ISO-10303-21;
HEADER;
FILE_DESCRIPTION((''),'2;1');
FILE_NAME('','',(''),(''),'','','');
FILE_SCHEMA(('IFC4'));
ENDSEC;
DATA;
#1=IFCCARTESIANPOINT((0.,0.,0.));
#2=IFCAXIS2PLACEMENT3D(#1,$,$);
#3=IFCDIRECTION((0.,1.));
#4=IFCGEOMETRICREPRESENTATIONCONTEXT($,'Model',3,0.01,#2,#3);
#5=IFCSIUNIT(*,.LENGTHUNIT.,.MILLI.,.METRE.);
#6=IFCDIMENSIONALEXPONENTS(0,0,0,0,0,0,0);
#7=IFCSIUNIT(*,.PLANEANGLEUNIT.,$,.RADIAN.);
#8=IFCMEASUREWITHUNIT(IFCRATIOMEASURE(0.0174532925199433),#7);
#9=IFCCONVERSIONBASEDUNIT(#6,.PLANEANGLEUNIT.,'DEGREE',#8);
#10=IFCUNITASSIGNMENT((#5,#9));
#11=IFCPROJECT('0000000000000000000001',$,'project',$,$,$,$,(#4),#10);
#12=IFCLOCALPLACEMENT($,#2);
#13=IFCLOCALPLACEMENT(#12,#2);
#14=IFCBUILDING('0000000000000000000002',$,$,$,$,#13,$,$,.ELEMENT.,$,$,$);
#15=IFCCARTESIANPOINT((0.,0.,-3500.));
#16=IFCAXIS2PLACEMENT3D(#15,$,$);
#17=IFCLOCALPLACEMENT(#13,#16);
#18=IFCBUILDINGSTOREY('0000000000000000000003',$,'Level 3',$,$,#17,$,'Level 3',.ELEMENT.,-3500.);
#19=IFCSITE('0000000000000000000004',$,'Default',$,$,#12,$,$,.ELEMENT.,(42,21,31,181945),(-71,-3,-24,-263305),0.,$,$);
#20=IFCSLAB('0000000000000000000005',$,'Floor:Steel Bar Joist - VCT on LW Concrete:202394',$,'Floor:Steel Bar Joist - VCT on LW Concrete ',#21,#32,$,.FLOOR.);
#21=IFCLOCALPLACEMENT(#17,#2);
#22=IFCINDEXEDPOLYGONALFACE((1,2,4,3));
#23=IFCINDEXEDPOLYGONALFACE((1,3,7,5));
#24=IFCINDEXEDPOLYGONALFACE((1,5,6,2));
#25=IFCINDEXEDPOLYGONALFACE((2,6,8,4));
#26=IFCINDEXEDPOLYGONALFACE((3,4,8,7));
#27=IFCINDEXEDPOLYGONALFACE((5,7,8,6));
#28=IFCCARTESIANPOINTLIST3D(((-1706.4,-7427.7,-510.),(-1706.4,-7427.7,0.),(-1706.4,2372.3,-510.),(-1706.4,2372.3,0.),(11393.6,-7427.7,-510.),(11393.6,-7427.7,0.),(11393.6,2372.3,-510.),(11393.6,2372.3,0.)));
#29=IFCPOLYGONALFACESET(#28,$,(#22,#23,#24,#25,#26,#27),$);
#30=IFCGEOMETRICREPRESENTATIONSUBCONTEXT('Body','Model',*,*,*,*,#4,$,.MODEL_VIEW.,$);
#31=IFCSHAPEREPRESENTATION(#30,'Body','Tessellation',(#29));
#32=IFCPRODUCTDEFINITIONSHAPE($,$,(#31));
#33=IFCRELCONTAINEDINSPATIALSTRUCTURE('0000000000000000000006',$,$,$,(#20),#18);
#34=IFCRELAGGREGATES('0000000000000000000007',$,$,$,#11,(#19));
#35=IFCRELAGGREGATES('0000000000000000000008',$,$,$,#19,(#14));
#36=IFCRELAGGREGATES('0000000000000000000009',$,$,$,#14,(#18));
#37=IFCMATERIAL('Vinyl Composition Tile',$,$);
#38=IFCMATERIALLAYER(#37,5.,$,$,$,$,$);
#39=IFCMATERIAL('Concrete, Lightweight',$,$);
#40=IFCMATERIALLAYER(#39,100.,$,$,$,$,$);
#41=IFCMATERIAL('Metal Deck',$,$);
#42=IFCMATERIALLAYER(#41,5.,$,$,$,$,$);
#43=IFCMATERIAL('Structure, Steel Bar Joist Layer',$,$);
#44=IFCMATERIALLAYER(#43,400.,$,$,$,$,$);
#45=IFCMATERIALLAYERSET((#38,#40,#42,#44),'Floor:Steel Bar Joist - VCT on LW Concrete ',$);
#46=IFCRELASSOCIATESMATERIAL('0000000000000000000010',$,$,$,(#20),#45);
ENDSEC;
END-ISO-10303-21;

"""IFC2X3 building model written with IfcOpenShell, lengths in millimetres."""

from ifc_helpers import new_model, entity, si_unit, converted_unit, direction, frame, frame_2d, origin, place, context, subcontext, project, spatial, rectangle, extrude, material, layer, layer_set, layer_usage, element, save


model = new_model("IFC2X3")

# Units and contexts
model_context = context("Model", 3, precision=0.01, world=origin(), true_north=direction((0.0, 1.0)))
body_context = subcontext(model_context, "Body", "Model", "MODEL_VIEW")
ifc_project = project(units=[si_unit("LENGTHUNIT", "METRE", prefix="MILLI"), converted_unit("PLANEANGLEUNIT", "DEGREE", entity("IfcRatioMeasure", 0.0174532925199433), si_unit("PLANEANGLEUNIT", "RADIAN"), dimensions=[0, 0, 0, 0, 0, 0, 0])], contexts=[model_context])

# Site, building, storey
site_placement = place(None, origin())
site = spatial("IfcSite", under=ifc_project, at=site_placement, Name="Default", CompositionType="ELEMENT", RefLatitude=(42, 21, 31, 181945), RefLongitude=(-71, -3, -24, -263305), RefElevation=0.0)
building_placement = place(site_placement, origin())
building = spatial("IfcBuilding", under=site, at=building_placement, CompositionType="ELEMENT")
storey_placement = place(building_placement, frame((0.0, 0.0, -3500.0)))
storey = spatial("IfcBuildingStorey", under=building, at=storey_placement, Name="Level 3", LongName="Level 3", CompositionType="ELEMENT", Elevation=-3500.0)

# Slab
ifc_material_1 = material(Name="Vinyl Composition Tile")
ifc_layer_1 = layer(ifc_material_1, 5.0)
ifc_material_2 = material(Name="Concrete, Lightweight")
ifc_layer_2 = layer(ifc_material_2, 100.0)
ifc_material_3 = material(Name="Metal Deck")
ifc_layer_3 = layer(ifc_material_3, 5.0)
ifc_material_4 = material(Name="Structure, Steel Bar Joist Layer")
ifc_layer_4 = layer(ifc_material_4, 400.0)
ifc_layer_set = layer_set([ifc_layer_1, ifc_layer_2, ifc_layer_3, ifc_layer_4], Name="Floor:Steel Bar Joist - VCT on LW Concrete ")
ifc_layer_usage = layer_usage(ifc_layer_set, "AXIS3", "POSITIVE", 0.0)
slab_placement = place(storey_placement, origin())
element("IfcSlab", 1, at=slab_placement, inside=storey, material=ifc_layer_usage, Name="Floor:Steel Bar Joist - VCT on LW Concrete:202394", ObjectType="Floor:Steel Bar Joist - VCT on LW Concrete ", PredefinedType="FLOOR", context=body_context, shape_type="SweptSolid", body=[
    extrude(rectangle(XDim=9800.0, YDim=13100.0, at=frame_2d((0.0, 0.0), x_axis=(1.0, 0.0))), frame((4843.6, -2527.7, 0.0), z_axis=(0.0, 0.0, -1.0), x_axis=(0.0, 1.0, 0.0)), (0.0, 0.0, 1.0), 510.0),
])

save(model, "model.ifc")
